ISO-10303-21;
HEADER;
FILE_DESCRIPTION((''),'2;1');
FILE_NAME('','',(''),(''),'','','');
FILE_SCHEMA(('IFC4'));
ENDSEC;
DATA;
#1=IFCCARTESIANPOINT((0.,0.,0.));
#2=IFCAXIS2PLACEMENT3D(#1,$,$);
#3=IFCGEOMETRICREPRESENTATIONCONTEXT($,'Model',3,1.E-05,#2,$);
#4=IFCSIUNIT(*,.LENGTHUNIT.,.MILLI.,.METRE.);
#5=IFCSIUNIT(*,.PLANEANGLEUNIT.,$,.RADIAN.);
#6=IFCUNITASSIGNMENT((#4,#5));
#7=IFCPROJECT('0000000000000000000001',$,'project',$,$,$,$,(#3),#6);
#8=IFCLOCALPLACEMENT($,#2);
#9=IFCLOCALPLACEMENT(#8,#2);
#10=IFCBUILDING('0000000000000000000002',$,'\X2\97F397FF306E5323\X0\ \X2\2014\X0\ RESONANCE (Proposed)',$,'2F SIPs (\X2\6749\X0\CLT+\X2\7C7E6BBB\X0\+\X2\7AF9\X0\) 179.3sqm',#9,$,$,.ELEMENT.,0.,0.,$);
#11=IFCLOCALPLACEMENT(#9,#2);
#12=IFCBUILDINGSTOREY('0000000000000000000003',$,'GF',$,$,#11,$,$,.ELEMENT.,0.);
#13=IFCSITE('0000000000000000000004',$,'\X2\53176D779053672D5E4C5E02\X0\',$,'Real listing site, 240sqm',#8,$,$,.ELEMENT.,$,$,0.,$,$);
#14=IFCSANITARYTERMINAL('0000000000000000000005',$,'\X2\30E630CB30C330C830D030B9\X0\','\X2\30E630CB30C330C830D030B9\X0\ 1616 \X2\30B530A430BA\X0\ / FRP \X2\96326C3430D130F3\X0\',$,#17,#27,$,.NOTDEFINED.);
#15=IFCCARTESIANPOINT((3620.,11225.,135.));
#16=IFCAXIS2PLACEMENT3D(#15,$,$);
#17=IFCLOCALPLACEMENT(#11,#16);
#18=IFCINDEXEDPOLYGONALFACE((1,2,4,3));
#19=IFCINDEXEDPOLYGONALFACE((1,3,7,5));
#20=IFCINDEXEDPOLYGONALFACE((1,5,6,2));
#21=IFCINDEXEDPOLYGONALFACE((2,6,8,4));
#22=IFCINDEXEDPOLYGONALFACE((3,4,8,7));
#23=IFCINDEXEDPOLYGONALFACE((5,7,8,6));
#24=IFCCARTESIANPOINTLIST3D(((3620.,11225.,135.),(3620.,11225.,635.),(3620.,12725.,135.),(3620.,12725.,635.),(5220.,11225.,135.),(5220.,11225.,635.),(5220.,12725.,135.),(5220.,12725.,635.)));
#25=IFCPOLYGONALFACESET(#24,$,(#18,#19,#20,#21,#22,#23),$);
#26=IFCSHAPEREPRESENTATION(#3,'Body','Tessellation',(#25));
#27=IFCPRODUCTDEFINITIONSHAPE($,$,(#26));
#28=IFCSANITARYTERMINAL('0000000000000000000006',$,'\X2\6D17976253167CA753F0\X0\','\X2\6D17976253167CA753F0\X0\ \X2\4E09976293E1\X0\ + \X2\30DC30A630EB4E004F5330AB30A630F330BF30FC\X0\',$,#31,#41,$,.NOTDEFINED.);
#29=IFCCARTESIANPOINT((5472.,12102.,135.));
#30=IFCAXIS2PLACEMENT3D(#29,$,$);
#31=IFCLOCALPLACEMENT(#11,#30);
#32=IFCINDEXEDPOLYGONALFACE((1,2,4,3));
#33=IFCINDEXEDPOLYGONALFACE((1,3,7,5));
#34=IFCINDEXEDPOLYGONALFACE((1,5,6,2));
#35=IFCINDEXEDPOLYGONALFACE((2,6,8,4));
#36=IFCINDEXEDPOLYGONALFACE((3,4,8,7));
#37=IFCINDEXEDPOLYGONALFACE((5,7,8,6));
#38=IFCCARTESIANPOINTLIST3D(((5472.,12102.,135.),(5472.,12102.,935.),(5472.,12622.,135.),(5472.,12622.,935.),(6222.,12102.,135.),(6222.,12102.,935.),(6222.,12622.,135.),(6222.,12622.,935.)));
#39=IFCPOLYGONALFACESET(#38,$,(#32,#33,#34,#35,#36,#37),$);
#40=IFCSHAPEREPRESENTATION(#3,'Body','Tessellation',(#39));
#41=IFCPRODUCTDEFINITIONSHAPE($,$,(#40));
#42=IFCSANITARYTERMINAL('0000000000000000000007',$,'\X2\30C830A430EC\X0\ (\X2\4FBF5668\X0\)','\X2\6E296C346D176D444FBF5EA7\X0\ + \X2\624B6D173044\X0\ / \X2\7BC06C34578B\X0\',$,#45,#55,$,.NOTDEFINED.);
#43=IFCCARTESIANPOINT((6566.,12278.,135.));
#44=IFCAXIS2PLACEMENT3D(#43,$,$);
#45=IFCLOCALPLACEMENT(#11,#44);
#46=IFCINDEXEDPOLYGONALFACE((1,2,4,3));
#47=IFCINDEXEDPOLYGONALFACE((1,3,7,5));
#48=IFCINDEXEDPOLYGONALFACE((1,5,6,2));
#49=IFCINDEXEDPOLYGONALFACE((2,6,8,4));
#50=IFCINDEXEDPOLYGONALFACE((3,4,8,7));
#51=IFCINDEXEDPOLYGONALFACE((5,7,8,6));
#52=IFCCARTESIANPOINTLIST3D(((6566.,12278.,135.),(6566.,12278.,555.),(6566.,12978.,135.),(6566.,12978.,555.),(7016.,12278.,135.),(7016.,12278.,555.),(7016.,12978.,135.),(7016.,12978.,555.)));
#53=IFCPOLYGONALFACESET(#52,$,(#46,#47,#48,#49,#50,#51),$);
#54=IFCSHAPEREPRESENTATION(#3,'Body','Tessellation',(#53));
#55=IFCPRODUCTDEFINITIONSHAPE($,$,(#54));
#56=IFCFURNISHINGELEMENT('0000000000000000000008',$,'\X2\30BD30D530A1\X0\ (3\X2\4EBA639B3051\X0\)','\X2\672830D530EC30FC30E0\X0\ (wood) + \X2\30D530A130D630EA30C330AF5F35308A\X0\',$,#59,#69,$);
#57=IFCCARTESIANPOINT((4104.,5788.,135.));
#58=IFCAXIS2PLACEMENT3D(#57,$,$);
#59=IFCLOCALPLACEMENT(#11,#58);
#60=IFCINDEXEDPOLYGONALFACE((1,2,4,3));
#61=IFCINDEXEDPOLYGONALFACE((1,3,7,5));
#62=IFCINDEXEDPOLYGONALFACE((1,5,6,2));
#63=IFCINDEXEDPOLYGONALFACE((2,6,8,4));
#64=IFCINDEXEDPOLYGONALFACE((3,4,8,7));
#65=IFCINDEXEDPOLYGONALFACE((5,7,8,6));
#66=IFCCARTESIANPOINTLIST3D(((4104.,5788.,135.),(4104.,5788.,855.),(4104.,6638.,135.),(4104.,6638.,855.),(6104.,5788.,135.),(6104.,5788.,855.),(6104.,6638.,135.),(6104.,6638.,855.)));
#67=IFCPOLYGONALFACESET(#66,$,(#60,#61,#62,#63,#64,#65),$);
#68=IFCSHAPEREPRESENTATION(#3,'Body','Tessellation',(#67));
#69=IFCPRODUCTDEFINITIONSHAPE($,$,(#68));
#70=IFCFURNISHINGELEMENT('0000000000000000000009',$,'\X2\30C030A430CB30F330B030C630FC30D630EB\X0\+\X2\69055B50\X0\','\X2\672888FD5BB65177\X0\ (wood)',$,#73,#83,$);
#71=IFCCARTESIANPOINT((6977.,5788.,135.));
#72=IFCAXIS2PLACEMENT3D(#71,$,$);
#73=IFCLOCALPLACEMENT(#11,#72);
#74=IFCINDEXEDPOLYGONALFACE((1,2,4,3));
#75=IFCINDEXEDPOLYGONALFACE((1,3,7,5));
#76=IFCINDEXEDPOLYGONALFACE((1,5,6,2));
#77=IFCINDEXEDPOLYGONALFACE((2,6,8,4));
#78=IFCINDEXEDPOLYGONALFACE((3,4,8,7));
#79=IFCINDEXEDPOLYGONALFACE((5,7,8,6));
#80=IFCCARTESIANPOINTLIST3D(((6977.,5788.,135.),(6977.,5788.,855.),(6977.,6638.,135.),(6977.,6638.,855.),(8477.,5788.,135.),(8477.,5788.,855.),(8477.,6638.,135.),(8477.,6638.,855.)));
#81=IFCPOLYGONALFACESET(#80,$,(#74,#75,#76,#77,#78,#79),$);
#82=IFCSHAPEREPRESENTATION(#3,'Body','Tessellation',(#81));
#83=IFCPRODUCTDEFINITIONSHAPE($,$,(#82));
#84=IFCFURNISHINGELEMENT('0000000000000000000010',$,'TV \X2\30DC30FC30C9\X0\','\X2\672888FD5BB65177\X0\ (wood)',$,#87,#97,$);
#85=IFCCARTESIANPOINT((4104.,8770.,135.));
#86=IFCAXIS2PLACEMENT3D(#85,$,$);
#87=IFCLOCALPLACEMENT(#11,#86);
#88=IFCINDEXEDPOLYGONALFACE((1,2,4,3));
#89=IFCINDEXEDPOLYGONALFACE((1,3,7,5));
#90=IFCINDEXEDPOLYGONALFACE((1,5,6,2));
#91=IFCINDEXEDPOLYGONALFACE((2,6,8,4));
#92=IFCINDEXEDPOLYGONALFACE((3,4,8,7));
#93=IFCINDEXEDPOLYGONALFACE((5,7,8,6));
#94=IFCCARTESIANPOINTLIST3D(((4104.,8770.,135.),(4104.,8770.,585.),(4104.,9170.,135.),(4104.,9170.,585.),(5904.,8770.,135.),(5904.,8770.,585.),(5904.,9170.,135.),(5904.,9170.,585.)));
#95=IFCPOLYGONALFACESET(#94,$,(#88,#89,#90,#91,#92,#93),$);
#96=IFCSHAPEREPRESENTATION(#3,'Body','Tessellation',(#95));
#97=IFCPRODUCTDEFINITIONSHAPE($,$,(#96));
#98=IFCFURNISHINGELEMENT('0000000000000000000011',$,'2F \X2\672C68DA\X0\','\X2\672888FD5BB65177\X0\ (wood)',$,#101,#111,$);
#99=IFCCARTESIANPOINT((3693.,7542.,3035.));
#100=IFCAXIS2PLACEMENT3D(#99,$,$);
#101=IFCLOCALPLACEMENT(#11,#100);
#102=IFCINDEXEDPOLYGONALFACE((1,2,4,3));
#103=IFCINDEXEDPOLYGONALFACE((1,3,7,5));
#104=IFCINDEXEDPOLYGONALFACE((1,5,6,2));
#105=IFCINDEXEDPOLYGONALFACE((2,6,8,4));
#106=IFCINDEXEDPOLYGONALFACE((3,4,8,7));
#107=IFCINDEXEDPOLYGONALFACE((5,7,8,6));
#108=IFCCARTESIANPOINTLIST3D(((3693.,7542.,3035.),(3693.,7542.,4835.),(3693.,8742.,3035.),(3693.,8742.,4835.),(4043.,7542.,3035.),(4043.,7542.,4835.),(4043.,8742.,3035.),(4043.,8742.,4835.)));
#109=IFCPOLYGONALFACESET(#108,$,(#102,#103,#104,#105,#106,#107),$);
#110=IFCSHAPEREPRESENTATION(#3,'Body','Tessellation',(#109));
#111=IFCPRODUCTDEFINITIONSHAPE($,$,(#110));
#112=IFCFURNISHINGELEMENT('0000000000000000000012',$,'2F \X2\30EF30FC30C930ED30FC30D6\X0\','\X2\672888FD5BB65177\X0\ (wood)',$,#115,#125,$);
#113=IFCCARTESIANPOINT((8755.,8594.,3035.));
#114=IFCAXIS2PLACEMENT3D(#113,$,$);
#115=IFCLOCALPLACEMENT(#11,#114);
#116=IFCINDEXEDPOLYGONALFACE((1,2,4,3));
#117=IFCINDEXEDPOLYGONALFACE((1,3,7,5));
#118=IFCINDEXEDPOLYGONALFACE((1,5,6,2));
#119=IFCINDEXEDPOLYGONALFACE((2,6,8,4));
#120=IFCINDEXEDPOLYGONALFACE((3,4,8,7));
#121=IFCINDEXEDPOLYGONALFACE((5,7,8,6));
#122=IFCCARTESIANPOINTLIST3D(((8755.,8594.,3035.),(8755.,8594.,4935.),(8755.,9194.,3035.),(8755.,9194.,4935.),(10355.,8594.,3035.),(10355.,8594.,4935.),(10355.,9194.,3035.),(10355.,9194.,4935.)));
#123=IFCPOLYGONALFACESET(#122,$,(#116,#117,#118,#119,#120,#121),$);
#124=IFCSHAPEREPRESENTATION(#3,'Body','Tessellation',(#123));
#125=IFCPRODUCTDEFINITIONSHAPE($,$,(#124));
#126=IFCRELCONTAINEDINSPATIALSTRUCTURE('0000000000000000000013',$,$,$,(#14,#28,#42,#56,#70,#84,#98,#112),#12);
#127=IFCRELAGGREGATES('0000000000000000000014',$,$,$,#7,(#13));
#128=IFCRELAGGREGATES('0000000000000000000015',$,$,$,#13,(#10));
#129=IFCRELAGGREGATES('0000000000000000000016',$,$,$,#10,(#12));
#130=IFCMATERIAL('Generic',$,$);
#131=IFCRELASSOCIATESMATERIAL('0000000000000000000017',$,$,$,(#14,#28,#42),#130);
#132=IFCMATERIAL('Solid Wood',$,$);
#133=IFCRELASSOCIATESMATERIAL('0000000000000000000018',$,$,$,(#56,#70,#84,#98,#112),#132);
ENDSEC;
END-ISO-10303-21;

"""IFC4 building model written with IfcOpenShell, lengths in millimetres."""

from ifc_helpers import new_model, si_unit, frame, frame_2d, origin, place, context, project, spatial, rectangle, extrude, material, element, save


model = new_model("IFC4")

# Units and contexts
model_context = context("Model", 3, precision=1e-05, world=origin())
ifc_project = project(units=[si_unit("LENGTHUNIT", "METRE", prefix="MILLI"), si_unit("PLANEANGLEUNIT", "RADIAN")], contexts=[model_context])

# Site, building, storey
site_placement = place(None, origin())
site = spatial("IfcSite", under=ifc_project, at=site_placement, Name="北海道札幌市", ObjectType="Real listing site, 240sqm", CompositionType="ELEMENT", RefElevation=0.0)
building_placement = place(site_placement, origin())
building = spatial("IfcBuilding", under=site, at=building_placement, Name="音響の匣 — RESONANCE (Proposed)", ObjectType="2F SIPs (杉CLT+籾殻+竹) 179.3sqm", CompositionType="ELEMENT", ElevationOfRefHeight=0.0, ElevationOfTerrain=0.0)
storey_placement = place(building_placement, origin())
storey = spatial("IfcBuildingStorey", under=building, at=storey_placement, Name="GF", CompositionType="ELEMENT", Elevation=0.0)

# Shared definitions
ifc_material_1 = material(Name="Generic")

# Shared definitions
ifc_material_2 = material(Name="Solid Wood")

# Sanitary terminals
sanitary_terminal_1_placement = place(storey_placement, frame((3620.0, 11225.0, 135.0)))
element("IfcSanitaryTerminal", 1, at=sanitary_terminal_1_placement, inside=storey, material=ifc_material_1, Name="ユニットバス", Description="ユニットバス 1616 サイズ / FRP 防水パン", PredefinedType="NOTDEFINED", context=model_context, shape_type="SweptSolid", body=[
    extrude(rectangle(XDim=1600.0, YDim=1500.0, at=frame_2d((800.0, 750.0))), frame((3620.0, 11225.0, 135.0)), (0.0, 0.0, 1.0), 500.0),
])
sanitary_terminal_2_placement = place(storey_placement, frame((5472.0, 12102.0, 135.0)))
element("IfcSanitaryTerminal", 2, at=sanitary_terminal_2_placement, inside=storey, material=ifc_material_1, Name="洗面化粧台", Description="洗面化粧台 三面鏡 + ボウル一体カウンター", PredefinedType="NOTDEFINED", context=model_context, shape_type="SweptSolid", body=[
    extrude(rectangle(XDim=750.0, YDim=520.0, at=frame_2d((375.0, 260.0))), frame((5472.0, 12102.0, 135.0)), (0.0, 0.0, 1.0), 800.0),
])
sanitary_terminal_3_placement = place(storey_placement, frame((6566.0, 12278.0, 135.0)))
element("IfcSanitaryTerminal", 3, at=sanitary_terminal_3_placement, inside=storey, material=ifc_material_1, Name="トイレ (便器)", Description="温水洗浄便座 + 手洗い / 節水型", PredefinedType="NOTDEFINED", context=model_context, shape_type="SweptSolid", body=[
    extrude(rectangle(XDim=450.0, YDim=700.0, at=frame_2d((225.0, 350.0))), frame((6566.0, 12278.0, 135.0)), (0.0, 0.0, 1.0), 420.0),
])

# Furnishing elements
furnishing_1_placement = place(storey_placement, frame((4104.0, 5788.0, 135.0)))
element("IfcFurnishingElement", 4, at=furnishing_1_placement, inside=storey, material=ifc_material_2, Name="ソファ (3人掛け)", Description="木フレーム (wood) + ファブリック張り", context=model_context, shape_type="SweptSolid", body=[
    extrude(rectangle(XDim=2000.0, YDim=850.0, at=frame_2d((1000.0, 425.0))), frame((4104.0, 5788.0, 135.0)), (0.0, 0.0, 1.0), 720.0),
])
furnishing_2_placement = place(storey_placement, frame((6977.0, 5788.0, 135.0)))
element("IfcFurnishingElement", 5, at=furnishing_2_placement, inside=storey, material=ifc_material_2, Name="ダイニングテーブル+椅子", Description="木製家具 (wood)", context=model_context, shape_type="SweptSolid", body=[
    extrude(rectangle(XDim=1500.0, YDim=850.0, at=frame_2d((750.0, 425.0))), frame((6977.0, 5788.0, 135.0)), (0.0, 0.0, 1.0), 720.0),
])
furnishing_3_placement = place(storey_placement, frame((4104.0, 8770.0, 135.0)))
element("IfcFurnishingElement", 6, at=furnishing_3_placement, inside=storey, material=ifc_material_2, Name="TV ボード", Description="木製家具 (wood)", context=model_context, shape_type="SweptSolid", body=[
    extrude(rectangle(XDim=1800.0, YDim=400.0, at=frame_2d((900.0, 200.0))), frame((4104.0, 8770.0, 135.0)), (0.0, 0.0, 1.0), 450.0),
])
furnishing_4_placement = place(storey_placement, frame((3693.0, 7542.0, 3035.0)))
element("IfcFurnishingElement", 7, at=furnishing_4_placement, inside=storey, material=ifc_material_2, Name="2F 本棚", Description="木製家具 (wood)", context=model_context, shape_type="SweptSolid", body=[
    extrude(rectangle(XDim=350.0, YDim=1200.0, at=frame_2d((175.0, 600.0))), frame((3693.0, 7542.0, 3035.0)), (0.0, 0.0, 1.0), 1800.0),
])
furnishing_5_placement = place(storey_placement, frame((8755.0, 8594.0, 3035.0)))
element("IfcFurnishingElement", 8, at=furnishing_5_placement, inside=storey, material=ifc_material_2, Name="2F ワードローブ", Description="木製家具 (wood)", context=model_context, shape_type="SweptSolid", body=[
    extrude(rectangle(XDim=1600.0, YDim=600.0, at=frame_2d((800.0, 300.0))), frame((8755.0, 8594.0, 3035.0)), (0.0, 0.0, 1.0), 1900.0),
])

save(model, "model.ifc")
